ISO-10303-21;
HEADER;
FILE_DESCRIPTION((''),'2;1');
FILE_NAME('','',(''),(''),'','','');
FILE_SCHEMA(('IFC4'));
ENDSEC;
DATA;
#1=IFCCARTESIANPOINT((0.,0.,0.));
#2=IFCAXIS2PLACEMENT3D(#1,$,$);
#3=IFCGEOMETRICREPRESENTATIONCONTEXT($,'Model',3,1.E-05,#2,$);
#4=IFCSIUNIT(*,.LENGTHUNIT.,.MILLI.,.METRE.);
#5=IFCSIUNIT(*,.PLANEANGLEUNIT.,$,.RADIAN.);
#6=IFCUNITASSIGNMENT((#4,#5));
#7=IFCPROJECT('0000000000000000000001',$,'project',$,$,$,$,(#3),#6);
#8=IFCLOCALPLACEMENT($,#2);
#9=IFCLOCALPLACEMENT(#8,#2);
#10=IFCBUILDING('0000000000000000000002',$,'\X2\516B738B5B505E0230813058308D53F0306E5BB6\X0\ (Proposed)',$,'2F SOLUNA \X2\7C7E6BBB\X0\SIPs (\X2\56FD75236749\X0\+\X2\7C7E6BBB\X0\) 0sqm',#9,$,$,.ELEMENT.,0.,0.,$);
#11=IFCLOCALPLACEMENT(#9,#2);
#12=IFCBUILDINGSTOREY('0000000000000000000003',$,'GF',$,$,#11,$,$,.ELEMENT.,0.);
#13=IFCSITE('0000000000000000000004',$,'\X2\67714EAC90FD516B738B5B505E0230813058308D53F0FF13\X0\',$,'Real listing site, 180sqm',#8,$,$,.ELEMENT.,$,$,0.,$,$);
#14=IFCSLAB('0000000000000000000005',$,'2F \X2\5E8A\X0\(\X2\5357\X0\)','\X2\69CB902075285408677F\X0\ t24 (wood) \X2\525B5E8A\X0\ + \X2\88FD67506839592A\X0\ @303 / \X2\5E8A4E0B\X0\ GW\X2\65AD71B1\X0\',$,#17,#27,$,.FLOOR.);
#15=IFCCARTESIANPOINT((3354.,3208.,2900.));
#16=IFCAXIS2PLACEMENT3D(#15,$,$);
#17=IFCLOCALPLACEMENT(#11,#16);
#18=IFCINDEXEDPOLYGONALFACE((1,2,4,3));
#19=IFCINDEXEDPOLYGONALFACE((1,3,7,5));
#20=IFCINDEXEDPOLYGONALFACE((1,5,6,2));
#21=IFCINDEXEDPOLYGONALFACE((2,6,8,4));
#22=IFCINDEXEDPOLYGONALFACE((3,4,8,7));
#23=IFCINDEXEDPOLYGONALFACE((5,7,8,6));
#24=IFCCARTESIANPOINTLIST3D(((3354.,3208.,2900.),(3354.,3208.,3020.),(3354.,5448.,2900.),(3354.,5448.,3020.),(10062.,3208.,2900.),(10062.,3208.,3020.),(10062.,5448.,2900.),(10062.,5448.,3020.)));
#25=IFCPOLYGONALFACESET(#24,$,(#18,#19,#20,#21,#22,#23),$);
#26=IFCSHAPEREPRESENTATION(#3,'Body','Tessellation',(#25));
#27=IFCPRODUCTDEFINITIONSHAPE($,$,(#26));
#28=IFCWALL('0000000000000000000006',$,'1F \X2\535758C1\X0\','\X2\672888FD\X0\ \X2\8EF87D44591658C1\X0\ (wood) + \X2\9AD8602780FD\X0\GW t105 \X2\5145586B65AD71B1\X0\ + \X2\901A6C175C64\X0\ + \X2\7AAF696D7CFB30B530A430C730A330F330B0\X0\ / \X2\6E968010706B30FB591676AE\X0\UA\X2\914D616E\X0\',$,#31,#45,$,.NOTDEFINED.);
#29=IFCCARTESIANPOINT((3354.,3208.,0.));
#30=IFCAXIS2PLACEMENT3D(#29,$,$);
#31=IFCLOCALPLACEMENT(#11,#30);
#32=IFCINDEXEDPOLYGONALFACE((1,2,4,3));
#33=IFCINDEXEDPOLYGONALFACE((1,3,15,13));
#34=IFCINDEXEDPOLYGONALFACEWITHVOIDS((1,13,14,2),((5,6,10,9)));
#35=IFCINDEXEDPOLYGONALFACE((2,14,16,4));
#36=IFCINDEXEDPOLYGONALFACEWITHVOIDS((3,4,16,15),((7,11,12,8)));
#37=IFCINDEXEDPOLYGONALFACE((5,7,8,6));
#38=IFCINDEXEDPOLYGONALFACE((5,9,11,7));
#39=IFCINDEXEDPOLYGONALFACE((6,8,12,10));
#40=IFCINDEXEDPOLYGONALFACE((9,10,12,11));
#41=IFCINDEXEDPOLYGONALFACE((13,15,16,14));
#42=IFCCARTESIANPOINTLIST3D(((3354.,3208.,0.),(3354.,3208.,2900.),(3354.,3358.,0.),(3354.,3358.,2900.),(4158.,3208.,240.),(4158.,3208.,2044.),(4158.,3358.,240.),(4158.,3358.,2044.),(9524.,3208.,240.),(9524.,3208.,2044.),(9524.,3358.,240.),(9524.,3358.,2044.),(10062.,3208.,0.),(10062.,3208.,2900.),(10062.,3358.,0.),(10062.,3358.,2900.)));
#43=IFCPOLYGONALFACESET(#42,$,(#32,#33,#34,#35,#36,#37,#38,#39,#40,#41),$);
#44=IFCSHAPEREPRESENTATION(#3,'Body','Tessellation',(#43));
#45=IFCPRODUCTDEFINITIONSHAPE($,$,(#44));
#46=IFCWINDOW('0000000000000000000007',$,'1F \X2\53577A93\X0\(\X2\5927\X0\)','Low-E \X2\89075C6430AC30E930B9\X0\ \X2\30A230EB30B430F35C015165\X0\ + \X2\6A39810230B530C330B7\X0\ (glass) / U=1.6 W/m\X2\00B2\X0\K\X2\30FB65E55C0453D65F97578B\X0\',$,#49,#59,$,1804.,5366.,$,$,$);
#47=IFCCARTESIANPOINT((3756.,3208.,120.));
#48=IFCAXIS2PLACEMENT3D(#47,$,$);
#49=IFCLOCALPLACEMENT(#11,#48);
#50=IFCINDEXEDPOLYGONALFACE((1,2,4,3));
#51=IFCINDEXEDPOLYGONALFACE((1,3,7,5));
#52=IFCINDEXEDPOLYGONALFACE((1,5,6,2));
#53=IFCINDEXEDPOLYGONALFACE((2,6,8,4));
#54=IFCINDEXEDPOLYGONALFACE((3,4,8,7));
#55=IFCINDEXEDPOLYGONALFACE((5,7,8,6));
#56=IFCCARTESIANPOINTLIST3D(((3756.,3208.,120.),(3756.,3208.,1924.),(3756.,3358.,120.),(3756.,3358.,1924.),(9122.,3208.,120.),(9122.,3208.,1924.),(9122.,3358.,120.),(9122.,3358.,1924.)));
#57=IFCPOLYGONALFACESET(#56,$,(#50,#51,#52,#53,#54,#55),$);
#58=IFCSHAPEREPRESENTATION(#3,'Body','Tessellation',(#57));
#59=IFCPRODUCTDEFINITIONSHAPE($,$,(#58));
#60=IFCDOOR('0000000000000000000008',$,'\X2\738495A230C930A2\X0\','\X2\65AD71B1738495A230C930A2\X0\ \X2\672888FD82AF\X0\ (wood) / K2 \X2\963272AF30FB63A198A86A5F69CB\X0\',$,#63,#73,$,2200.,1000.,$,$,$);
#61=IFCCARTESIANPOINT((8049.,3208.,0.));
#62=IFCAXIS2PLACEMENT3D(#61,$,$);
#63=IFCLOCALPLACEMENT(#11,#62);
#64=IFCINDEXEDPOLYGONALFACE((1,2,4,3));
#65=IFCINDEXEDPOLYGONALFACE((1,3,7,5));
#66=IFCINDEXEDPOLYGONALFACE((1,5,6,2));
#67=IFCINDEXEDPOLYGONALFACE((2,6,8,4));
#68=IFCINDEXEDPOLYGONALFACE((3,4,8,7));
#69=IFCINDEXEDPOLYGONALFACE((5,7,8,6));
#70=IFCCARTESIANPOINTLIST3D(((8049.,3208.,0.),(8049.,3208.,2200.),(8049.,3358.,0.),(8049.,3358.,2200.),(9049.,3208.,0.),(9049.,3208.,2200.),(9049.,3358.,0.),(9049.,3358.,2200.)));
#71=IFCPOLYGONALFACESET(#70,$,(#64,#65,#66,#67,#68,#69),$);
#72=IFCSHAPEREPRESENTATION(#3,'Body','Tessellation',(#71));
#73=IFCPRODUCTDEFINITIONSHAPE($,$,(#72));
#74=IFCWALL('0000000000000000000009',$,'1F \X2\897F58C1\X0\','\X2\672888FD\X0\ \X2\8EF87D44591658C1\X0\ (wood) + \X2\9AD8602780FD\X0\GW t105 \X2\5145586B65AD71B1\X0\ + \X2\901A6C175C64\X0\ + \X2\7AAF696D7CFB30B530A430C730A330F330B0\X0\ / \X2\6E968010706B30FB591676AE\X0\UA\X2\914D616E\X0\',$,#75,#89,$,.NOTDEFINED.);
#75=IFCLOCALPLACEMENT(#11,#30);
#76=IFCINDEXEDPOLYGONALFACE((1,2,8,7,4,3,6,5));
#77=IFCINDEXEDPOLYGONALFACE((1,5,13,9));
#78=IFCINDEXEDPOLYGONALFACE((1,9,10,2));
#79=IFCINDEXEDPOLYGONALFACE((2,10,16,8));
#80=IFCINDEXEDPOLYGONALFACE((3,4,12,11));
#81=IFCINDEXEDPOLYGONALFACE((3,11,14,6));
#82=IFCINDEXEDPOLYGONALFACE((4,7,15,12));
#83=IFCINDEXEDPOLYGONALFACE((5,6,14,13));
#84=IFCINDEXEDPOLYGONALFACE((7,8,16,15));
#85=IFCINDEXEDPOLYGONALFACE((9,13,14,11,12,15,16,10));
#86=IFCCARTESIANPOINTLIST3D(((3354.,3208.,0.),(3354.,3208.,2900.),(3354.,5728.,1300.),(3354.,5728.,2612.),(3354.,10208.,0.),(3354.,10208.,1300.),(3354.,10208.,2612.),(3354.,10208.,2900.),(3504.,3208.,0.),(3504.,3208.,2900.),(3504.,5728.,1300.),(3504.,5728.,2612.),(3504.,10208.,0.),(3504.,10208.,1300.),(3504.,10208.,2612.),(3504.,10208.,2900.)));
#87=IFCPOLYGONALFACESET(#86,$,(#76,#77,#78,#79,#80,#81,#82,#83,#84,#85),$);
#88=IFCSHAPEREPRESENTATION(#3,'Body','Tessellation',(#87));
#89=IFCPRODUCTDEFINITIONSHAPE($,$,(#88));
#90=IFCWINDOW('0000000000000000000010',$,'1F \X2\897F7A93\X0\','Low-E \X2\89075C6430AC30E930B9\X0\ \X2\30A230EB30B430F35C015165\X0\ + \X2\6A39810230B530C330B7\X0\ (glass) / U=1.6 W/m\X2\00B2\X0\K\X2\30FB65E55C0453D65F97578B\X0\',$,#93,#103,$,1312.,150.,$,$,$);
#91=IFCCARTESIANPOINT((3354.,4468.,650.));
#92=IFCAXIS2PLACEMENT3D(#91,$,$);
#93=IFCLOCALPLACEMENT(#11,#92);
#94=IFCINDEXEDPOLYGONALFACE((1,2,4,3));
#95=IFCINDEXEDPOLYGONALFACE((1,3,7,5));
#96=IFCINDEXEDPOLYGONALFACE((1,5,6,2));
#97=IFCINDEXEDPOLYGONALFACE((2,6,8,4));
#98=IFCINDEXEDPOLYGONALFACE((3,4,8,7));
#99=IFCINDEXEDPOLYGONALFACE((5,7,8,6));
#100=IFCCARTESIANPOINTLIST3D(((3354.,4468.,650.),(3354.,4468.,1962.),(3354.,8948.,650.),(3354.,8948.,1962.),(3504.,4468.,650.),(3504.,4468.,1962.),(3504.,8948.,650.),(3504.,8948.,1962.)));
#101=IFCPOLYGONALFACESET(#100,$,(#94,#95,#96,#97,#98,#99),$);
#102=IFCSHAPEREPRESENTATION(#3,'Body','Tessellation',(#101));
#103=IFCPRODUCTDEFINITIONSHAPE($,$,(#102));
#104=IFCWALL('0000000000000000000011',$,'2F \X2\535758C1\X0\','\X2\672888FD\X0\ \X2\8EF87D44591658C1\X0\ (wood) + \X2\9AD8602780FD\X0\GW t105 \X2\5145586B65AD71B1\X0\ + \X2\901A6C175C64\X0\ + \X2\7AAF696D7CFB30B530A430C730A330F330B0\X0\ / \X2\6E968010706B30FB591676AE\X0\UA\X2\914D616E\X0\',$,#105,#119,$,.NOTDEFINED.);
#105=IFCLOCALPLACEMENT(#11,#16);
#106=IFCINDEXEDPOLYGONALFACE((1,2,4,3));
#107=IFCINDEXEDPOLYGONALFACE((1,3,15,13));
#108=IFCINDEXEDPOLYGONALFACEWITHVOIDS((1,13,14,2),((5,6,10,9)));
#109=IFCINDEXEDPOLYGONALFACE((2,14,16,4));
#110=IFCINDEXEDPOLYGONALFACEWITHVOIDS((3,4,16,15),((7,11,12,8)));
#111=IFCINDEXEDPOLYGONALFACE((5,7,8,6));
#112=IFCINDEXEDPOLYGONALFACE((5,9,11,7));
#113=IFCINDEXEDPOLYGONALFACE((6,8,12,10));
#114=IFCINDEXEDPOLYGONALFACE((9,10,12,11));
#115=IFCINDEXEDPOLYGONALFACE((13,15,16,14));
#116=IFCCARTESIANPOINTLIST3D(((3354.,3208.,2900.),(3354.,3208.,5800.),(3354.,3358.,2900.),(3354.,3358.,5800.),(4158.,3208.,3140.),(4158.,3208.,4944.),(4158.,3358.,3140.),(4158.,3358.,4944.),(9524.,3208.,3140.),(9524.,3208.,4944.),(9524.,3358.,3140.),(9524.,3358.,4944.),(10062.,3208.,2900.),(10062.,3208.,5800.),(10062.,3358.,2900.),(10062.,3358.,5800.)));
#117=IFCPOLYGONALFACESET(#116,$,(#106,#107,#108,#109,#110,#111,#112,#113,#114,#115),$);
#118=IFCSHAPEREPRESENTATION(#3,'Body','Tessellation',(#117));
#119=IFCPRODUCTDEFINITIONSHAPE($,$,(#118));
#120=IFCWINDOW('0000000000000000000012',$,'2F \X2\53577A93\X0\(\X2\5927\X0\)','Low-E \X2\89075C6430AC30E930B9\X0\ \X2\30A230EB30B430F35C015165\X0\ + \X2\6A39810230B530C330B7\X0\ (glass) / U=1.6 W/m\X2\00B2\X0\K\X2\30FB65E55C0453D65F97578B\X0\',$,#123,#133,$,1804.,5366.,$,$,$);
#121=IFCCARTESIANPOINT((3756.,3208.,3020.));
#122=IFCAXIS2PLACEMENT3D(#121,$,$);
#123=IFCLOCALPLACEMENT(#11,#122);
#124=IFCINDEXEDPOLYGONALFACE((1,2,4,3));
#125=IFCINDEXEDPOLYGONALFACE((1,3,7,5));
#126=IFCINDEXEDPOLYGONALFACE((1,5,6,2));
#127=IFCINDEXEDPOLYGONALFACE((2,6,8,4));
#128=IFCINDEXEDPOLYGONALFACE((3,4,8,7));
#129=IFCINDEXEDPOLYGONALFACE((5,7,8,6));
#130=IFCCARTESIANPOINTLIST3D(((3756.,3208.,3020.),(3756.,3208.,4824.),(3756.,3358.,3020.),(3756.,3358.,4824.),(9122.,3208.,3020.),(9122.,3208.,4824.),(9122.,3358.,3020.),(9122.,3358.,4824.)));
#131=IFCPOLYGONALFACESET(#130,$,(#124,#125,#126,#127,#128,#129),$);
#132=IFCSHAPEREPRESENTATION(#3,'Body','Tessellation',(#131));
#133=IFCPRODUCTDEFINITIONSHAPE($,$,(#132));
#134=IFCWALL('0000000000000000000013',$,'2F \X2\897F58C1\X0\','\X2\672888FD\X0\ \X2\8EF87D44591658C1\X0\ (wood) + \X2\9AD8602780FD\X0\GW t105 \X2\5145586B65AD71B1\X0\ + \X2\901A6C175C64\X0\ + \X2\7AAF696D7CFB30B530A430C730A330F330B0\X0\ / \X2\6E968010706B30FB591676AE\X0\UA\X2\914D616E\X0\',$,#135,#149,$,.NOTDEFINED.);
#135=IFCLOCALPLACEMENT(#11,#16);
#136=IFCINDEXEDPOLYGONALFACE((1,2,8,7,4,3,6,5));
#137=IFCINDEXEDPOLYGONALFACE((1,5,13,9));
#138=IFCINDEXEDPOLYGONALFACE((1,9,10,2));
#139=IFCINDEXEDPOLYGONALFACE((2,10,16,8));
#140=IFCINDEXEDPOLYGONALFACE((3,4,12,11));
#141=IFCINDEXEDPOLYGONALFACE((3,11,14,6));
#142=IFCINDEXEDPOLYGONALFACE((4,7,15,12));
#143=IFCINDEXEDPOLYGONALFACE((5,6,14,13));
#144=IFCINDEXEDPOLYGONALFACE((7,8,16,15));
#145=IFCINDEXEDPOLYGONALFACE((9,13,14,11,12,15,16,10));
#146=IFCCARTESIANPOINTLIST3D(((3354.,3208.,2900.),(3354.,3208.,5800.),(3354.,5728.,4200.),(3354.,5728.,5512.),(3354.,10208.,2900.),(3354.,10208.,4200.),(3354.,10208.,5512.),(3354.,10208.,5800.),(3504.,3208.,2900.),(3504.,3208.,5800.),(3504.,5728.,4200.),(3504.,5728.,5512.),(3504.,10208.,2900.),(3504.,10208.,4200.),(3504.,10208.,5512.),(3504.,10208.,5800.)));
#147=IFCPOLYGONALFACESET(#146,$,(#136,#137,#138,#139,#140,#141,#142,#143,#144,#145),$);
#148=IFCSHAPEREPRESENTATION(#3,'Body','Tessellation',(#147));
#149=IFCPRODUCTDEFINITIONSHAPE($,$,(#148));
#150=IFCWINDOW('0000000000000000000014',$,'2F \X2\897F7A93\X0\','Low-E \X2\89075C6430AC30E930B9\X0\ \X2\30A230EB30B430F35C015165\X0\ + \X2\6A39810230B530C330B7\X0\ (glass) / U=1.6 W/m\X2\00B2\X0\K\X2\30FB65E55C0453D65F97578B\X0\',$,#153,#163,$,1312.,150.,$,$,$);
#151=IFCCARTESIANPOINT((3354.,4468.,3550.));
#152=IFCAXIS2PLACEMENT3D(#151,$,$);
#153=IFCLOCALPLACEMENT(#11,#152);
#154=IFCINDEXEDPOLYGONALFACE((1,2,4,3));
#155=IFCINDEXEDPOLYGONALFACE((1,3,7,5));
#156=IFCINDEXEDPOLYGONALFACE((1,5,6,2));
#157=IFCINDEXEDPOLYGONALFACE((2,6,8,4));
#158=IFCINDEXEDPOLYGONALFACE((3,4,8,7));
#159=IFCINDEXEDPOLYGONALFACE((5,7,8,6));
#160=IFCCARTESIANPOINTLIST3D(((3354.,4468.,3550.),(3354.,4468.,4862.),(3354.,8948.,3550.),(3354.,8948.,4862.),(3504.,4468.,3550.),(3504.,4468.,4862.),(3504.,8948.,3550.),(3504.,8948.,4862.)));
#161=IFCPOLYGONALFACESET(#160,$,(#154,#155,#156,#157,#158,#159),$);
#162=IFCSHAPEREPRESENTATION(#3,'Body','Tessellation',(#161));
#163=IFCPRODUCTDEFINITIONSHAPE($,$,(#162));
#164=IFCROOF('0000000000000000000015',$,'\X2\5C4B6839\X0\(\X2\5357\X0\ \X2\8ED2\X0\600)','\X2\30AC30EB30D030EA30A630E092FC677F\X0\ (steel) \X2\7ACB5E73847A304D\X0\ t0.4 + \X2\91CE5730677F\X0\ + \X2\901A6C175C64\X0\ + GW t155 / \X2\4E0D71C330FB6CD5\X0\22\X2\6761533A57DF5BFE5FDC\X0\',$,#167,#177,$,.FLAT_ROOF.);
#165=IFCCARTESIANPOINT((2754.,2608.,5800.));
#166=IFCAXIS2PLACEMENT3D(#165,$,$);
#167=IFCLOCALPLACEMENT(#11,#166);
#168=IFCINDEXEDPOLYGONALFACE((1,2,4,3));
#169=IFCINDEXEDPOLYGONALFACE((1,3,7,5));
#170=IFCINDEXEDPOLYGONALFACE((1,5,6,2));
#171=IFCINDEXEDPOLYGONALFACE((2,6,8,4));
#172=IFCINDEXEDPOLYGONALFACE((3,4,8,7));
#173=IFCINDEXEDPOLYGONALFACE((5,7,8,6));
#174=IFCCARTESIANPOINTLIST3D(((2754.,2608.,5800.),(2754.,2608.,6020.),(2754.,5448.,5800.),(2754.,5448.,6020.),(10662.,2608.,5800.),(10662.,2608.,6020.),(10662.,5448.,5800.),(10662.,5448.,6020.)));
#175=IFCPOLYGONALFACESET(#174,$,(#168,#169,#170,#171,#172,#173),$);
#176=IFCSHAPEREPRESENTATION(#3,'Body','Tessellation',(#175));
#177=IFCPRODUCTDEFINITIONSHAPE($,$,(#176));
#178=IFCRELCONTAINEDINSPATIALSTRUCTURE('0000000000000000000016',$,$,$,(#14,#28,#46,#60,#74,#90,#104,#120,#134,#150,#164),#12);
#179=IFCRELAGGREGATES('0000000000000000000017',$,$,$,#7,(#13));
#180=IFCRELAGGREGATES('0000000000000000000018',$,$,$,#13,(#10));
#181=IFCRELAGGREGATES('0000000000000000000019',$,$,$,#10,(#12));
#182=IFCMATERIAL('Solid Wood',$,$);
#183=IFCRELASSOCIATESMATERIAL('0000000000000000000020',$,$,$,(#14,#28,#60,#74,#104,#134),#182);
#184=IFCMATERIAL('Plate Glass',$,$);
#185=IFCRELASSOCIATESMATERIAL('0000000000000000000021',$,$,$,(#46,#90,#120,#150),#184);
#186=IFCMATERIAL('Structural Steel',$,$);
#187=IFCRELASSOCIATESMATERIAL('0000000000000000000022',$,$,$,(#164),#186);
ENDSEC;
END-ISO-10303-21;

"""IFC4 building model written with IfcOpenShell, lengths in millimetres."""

from ifc_helpers import new_model, si_unit, frame, frame_2d, origin, place, context, project, spatial, rectangle, extrude, material, element, fill, save


model = new_model("IFC4")

# Units and contexts
model_context = context("Model", 3, precision=1e-05, world=origin())
ifc_project = project(units=[si_unit("LENGTHUNIT", "METRE", prefix="MILLI"), si_unit("PLANEANGLEUNIT", "RADIAN")], contexts=[model_context])

# Site, building, storey
site_placement = place(None, origin())
site = spatial("IfcSite", under=ifc_project, at=site_placement, Name="東京都八王子市めじろ台３", ObjectType="Real listing site, 180sqm", CompositionType="ELEMENT", RefElevation=0.0)
building_placement = place(site_placement, origin())
building = spatial("IfcBuilding", under=site, at=building_placement, Name="八王子市めじろ台の家 (Proposed)", ObjectType="2F SOLUNA 籾殻SIPs (国産杉+籾殻) 0sqm", CompositionType="ELEMENT", ElevationOfRefHeight=0.0, ElevationOfTerrain=0.0)
storey_placement = place(building_placement, origin())
storey = spatial("IfcBuildingStorey", under=building, at=storey_placement, Name="GF", CompositionType="ELEMENT", Elevation=0.0)

# Slab
ifc_material_1 = material(Name="Solid Wood")
slab_1_placement = place(storey_placement, frame((3354.0, 3208.0, 2900.0)))
element("IfcSlab", 1, at=slab_1_placement, inside=storey, material=ifc_material_1, Name="2F 床(南)", Description="構造用合板 t24 (wood) 剛床 + 製材根太 @303 / 床下 GW断熱", PredefinedType="FLOOR", context=model_context, shape_type="SweptSolid", body=[
    extrude(rectangle(XDim=6708.0, YDim=2240.0, at=frame_2d((3354.0, 1120.0))), frame((3354.0, 3208.0, 2900.0)), (0.0, 0.0, 1.0), 120.0),
])

# Wall, openings, window, door
wall_1_placement = place(storey_placement, frame((3354.0, 3208.0, 0.0)))
wall_1 = element("IfcWall", 2, at=wall_1_placement, inside=storey, material=ifc_material_1, Name="1F 南壁", Description="木製 軸組外壁 (wood) + 高性能GW t105 充填断熱 + 通気層 + 窯業系サイディング / 準耐火・外皮UA配慮", PredefinedType="NOTDEFINED", context=model_context, shape_type="SweptSolid", body=[
    extrude(rectangle(XDim=6708.0, YDim=150.0, at=frame_2d((3354.0, 75.0))), frame((3354.0, 3208.0, 0.0)), (0.0, 0.0, 1.0), 2900.0),
])
opening_1_placement = place(storey_placement, frame((3756.0, 3208.0, 120.0)))
opening_1 = element("IfcOpeningElement", 3, at=opening_1_placement, cuts=wall_1, PredefinedType="NOTDEFINED", context=model_context, shape_type="SweptSolid", body=[
    extrude(rectangle(XDim=5366.0, YDim=150.0, at=frame_2d((2683.0, 75.0))), frame((3756.0, 3208.0, 120.0)), (0.0, 0.0, 1.0), 1804.0),
])
opening_2_placement = place(storey_placement, frame((8049.0, 3208.0, 0.0)))
opening_2 = element("IfcOpeningElement", 4, at=opening_2_placement, cuts=wall_1, PredefinedType="NOTDEFINED", context=model_context, shape_type="SweptSolid", body=[
    extrude(rectangle(XDim=1000.0, YDim=150.0, at=frame_2d((500.0, 75.0))), frame((8049.0, 3208.0, 0.0)), (0.0, 0.0, 1.0), 2200.0),
])
ifc_material_2 = material(Name="Plate Glass")
window_1_placement = place(storey_placement, frame((3756.0, 3208.0, 120.0)))
window_1 = element("IfcWindow", 5, at=window_1_placement, inside=storey, material=ifc_material_2, Name="1F 南窓(大)", Description="Low-E 複層ガラス アルゴン封入 + 樹脂サッシ (glass) / U=1.6 W/m²K・日射取得型", OverallHeight=1804.0, OverallWidth=5366.0, context=model_context, shape_type="SweptSolid", body=[
    extrude(rectangle(XDim=5366.0, YDim=150.0, at=frame_2d((2683.0, 75.0))), frame((3756.0, 3208.0, 120.0)), (0.0, 0.0, 1.0), 1804.0),
])
fill(opening_1, window_1)
door_placement = place(storey_placement, frame((8049.0, 3208.0, 0.0)))
door = element("IfcDoor", 6, at=door_placement, inside=storey, material=ifc_material_1, Name="玄関ドア", Description="断熱玄関ドア 木製芯 (wood) / K2 防犯・採風機構", OverallHeight=2200.0, OverallWidth=1000.0, context=model_context, shape_type="SweptSolid", body=[
    extrude(rectangle(XDim=1000.0, YDim=150.0, at=frame_2d((500.0, 75.0))), frame((8049.0, 3208.0, 0.0)), (0.0, 0.0, 1.0), 2200.0),
])
fill(opening_2, door)

# Walls, openings, windows
wall_2_placement = place(storey_placement, frame((3354.0, 3208.0, 0.0)))
wall_2 = element("IfcWall", 7, at=wall_2_placement, inside=storey, material=ifc_material_1, Name="1F 西壁", Description="木製 軸組外壁 (wood) + 高性能GW t105 充填断熱 + 通気層 + 窯業系サイディング / 準耐火・外皮UA配慮", PredefinedType="NOTDEFINED", context=model_context, shape_type="SweptSolid", body=[
    extrude(rectangle(XDim=150.0, YDim=7000.0, at=frame_2d((75.0, 3500.0))), frame((3354.0, 3208.0, 0.0)), (0.0, 0.0, 1.0), 2900.0),
])
opening_3_placement = place(storey_placement, frame((3354.0, 4468.0, 650.0)))
opening_3 = element("IfcOpeningElement", 8, at=opening_3_placement, cuts=wall_2, PredefinedType="NOTDEFINED", context=model_context, shape_type="SweptSolid", body=[
    extrude(rectangle(XDim=150.0, YDim=4480.0, at=frame_2d((75.0, 2240.0))), frame((3354.0, 4468.0, 650.0)), (0.0, 0.0, 1.0), 1312.0),
])
window_2_placement = place(storey_placement, frame((3354.0, 4468.0, 650.0)))
window_2 = element("IfcWindow", 9, at=window_2_placement, inside=storey, material=ifc_material_2, Name="1F 西窓", Description="Low-E 複層ガラス アルゴン封入 + 樹脂サッシ (glass) / U=1.6 W/m²K・日射取得型", OverallHeight=1312.0, OverallWidth=150.0, context=model_context, shape_type="SweptSolid", body=[
    extrude(rectangle(XDim=150.0, YDim=4480.0, at=frame_2d((75.0, 2240.0))), frame((3354.0, 4468.0, 650.0)), (0.0, 0.0, 1.0), 1312.0),
])
fill(opening_3, window_2)
wall_3_placement = place(storey_placement, frame((3354.0, 3208.0, 2900.0)))
wall_3 = element("IfcWall", 10, at=wall_3_placement, inside=storey, material=ifc_material_1, Name="2F 南壁", Description="木製 軸組外壁 (wood) + 高性能GW t105 充填断熱 + 通気層 + 窯業系サイディング / 準耐火・外皮UA配慮", PredefinedType="NOTDEFINED", context=model_context, shape_type="SweptSolid", body=[
    extrude(rectangle(XDim=6708.0, YDim=150.0, at=frame_2d((3354.0, 75.0))), frame((3354.0, 3208.0, 2900.0)), (0.0, 0.0, 1.0), 2900.0),
])
opening_4_placement = place(storey_placement, frame((3756.0, 3208.0, 3020.0)))
opening_4 = element("IfcOpeningElement", 11, at=opening_4_placement, cuts=wall_3, PredefinedType="NOTDEFINED", context=model_context, shape_type="SweptSolid", body=[
    extrude(rectangle(XDim=5366.0, YDim=150.0, at=frame_2d((2683.0, 75.0))), frame((3756.0, 3208.0, 3020.0)), (0.0, 0.0, 1.0), 1804.0),
])
window_3_placement = place(storey_placement, frame((3756.0, 3208.0, 3020.0)))
window_3 = element("IfcWindow", 12, at=window_3_placement, inside=storey, material=ifc_material_2, Name="2F 南窓(大)", Description="Low-E 複層ガラス アルゴン封入 + 樹脂サッシ (glass) / U=1.6 W/m²K・日射取得型", OverallHeight=1804.0, OverallWidth=5366.0, context=model_context, shape_type="SweptSolid", body=[
    extrude(rectangle(XDim=5366.0, YDim=150.0, at=frame_2d((2683.0, 75.0))), frame((3756.0, 3208.0, 3020.0)), (0.0, 0.0, 1.0), 1804.0),
])
fill(opening_4, window_3)
wall_4_placement = place(storey_placement, frame((3354.0, 3208.0, 2900.0)))
wall_4 = element("IfcWall", 13, at=wall_4_placement, inside=storey, material=ifc_material_1, Name="2F 西壁", Description="木製 軸組外壁 (wood) + 高性能GW t105 充填断熱 + 通気層 + 窯業系サイディング / 準耐火・外皮UA配慮", PredefinedType="NOTDEFINED", context=model_context, shape_type="SweptSolid", body=[
    extrude(rectangle(XDim=150.0, YDim=7000.0, at=frame_2d((75.0, 3500.0))), frame((3354.0, 3208.0, 2900.0)), (0.0, 0.0, 1.0), 2900.0),
])
opening_5_placement = place(storey_placement, frame((3354.0, 4468.0, 3550.0)))
opening_5 = element("IfcOpeningElement", 14, at=opening_5_placement, cuts=wall_4, PredefinedType="NOTDEFINED", context=model_context, shape_type="SweptSolid", body=[
    extrude(rectangle(XDim=150.0, YDim=4480.0, at=frame_2d((75.0, 2240.0))), frame((3354.0, 4468.0, 3550.0)), (0.0, 0.0, 1.0), 1312.0),
])
window_4_placement = place(storey_placement, frame((3354.0, 4468.0, 3550.0)))
window_4 = element("IfcWindow", 15, at=window_4_placement, inside=storey, material=ifc_material_2, Name="2F 西窓", Description="Low-E 複層ガラス アルゴン封入 + 樹脂サッシ (glass) / U=1.6 W/m²K・日射取得型", OverallHeight=1312.0, OverallWidth=150.0, context=model_context, shape_type="SweptSolid", body=[
    extrude(rectangle(XDim=150.0, YDim=4480.0, at=frame_2d((75.0, 2240.0))), frame((3354.0, 4468.0, 3550.0)), (0.0, 0.0, 1.0), 1312.0),
])
fill(opening_5, window_4)

# Roof
ifc_material_3 = material(Name="Structural Steel")
roof_1_placement = place(storey_placement, frame((2754.0, 2608.0, 5800.0)))
element("IfcRoof", 16, at=roof_1_placement, inside=storey, material=ifc_material_3, Name="屋根(南 軒600)", Description="ガルバリウム鋼板 (steel) 立平葺き t0.4 + 野地板 + 通気層 + GW t155 / 不燃・法22条区域対応", PredefinedType="FLAT_ROOF", context=model_context, shape_type="SweptSolid", body=[
    extrude(rectangle(XDim=7908.0, YDim=2840.0, at=frame_2d((3954.0, 1420.0))), frame((2754.0, 2608.0, 5800.0)), (0.0, 0.0, 1.0), 220.0),
])

save(model, "model.ifc")
